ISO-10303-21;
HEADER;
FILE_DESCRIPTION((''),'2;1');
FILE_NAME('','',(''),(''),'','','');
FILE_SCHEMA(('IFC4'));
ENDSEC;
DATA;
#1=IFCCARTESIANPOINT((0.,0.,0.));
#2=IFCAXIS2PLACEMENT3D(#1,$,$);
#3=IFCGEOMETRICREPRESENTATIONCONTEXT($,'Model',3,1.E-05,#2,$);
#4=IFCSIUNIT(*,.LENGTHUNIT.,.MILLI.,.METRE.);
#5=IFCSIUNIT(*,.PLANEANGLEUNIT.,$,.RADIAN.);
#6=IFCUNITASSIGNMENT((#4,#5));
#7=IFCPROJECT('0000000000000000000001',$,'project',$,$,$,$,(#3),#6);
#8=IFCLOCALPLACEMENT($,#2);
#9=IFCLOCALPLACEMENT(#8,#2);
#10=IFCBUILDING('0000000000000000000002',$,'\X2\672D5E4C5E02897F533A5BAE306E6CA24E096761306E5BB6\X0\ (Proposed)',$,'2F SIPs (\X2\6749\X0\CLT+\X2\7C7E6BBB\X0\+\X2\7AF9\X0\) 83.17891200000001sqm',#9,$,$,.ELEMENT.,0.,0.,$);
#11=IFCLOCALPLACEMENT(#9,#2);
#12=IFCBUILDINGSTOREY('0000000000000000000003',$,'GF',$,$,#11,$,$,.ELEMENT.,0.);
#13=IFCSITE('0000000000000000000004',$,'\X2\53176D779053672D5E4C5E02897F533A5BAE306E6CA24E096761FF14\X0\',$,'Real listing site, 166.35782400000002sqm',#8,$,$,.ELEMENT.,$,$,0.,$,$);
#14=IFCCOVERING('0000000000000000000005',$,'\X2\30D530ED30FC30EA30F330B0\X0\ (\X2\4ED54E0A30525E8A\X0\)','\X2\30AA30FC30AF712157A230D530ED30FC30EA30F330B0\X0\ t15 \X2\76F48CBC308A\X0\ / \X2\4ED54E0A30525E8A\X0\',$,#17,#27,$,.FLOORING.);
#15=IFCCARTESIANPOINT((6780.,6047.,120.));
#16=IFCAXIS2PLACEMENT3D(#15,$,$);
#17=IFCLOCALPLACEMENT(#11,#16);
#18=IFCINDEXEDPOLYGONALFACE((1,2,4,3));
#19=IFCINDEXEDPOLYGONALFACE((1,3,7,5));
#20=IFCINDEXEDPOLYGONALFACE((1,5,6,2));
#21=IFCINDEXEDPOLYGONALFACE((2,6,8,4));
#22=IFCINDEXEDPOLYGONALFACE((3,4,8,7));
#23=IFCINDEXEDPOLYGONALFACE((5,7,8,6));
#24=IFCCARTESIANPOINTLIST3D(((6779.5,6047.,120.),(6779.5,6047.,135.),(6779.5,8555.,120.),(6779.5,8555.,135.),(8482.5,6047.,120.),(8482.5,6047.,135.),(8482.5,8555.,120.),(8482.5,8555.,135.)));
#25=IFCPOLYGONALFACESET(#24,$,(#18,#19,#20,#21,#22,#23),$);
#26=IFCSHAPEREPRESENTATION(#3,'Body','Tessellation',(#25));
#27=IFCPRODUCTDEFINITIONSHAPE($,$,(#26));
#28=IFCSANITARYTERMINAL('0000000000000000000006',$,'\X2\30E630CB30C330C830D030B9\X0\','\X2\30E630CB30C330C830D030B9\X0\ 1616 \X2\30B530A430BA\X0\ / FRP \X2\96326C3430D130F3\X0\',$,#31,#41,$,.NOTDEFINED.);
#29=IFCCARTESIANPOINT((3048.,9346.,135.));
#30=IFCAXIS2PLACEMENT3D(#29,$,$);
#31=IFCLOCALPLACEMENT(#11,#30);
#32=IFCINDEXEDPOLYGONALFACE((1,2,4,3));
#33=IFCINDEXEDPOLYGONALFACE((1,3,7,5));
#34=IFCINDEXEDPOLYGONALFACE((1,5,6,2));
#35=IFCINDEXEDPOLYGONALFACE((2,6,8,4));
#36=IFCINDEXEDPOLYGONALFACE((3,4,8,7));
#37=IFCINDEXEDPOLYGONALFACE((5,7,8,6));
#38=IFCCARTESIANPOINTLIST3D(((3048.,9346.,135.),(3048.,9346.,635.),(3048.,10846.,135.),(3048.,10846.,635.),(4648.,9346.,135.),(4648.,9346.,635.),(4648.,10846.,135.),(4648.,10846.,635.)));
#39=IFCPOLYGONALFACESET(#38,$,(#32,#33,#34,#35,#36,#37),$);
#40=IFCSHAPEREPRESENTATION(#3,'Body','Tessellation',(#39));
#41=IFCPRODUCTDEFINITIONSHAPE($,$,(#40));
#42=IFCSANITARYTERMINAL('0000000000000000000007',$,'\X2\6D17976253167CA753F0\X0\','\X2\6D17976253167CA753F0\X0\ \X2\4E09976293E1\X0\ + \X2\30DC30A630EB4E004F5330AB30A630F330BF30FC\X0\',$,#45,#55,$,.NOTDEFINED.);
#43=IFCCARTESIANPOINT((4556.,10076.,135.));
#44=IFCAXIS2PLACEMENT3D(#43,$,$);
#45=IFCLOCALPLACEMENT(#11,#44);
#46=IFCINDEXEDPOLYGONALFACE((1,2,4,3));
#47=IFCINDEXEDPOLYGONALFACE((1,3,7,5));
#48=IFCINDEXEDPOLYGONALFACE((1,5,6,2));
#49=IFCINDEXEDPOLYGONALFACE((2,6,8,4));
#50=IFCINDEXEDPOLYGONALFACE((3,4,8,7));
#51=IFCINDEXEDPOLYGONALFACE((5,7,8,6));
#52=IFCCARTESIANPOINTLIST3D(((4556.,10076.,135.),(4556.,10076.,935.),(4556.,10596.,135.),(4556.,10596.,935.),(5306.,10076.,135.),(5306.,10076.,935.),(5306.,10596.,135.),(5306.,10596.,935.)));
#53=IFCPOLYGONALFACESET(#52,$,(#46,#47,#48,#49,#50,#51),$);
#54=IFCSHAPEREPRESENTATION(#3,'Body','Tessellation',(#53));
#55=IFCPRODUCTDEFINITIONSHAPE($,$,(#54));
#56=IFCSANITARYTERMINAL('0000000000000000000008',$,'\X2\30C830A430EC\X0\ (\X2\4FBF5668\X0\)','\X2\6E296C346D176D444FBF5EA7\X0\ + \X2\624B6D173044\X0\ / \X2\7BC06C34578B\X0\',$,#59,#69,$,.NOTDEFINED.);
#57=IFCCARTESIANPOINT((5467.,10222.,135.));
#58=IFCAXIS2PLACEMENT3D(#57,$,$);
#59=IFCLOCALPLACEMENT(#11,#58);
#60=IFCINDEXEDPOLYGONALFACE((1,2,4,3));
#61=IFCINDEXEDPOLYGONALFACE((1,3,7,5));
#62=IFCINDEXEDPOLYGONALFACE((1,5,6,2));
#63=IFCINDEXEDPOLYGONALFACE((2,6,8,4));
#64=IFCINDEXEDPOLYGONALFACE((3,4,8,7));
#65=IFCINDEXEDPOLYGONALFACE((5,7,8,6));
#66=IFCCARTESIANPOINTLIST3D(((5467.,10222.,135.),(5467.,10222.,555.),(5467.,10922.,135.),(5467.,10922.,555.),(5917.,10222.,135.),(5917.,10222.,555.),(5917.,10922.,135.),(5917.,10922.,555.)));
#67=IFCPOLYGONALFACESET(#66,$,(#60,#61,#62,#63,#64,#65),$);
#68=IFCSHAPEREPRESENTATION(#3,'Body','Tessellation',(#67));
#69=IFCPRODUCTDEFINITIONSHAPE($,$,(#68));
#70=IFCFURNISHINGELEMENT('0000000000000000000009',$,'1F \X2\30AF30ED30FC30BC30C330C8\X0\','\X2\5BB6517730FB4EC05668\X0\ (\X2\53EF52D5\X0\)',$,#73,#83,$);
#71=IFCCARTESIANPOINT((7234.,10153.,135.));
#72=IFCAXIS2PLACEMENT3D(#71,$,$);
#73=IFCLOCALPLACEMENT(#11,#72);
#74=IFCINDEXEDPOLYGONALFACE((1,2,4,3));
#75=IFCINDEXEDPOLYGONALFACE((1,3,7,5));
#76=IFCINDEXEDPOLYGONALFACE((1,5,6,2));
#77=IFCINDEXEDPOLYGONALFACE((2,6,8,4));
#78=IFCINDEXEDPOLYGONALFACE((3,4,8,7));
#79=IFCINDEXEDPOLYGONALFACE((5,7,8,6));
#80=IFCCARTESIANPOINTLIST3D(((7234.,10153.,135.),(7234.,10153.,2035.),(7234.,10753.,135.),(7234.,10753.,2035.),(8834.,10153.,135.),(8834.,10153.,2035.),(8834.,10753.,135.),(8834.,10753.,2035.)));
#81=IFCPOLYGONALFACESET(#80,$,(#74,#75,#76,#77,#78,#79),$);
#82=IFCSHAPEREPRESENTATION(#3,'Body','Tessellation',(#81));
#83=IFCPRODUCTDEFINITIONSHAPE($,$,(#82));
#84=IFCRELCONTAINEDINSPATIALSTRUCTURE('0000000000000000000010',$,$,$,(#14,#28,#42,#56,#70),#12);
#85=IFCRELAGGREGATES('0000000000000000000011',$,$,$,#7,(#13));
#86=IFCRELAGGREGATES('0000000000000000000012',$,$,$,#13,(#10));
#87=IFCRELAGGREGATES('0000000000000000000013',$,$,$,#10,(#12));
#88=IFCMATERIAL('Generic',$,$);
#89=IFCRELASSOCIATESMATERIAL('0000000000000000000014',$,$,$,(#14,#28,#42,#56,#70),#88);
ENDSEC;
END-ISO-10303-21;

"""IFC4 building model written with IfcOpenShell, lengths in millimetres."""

from ifc_helpers import new_model, si_unit, frame, frame_2d, origin, place, context, project, spatial, rectangle, extrude, material, element, save


model = new_model("IFC4")

# Units and contexts
model_context = context("Model", 3, precision=1e-05, world=origin())
ifc_project = project(units=[si_unit("LENGTHUNIT", "METRE", prefix="MILLI"), si_unit("PLANEANGLEUNIT", "RADIAN")], contexts=[model_context])

# Site, building, storey
site_placement = place(None, origin())
site = spatial("IfcSite", under=ifc_project, at=site_placement, Name="北海道札幌市西区宮の沢三条４", ObjectType="Real listing site, 166.35782400000002sqm", CompositionType="ELEMENT", RefElevation=0.0)
building_placement = place(site_placement, origin())
building = spatial("IfcBuilding", under=site, at=building_placement, Name="札幌市西区宮の沢三条の家 (Proposed)", ObjectType="2F SIPs (杉CLT+籾殻+竹) 83.17891200000001sqm", CompositionType="ELEMENT", ElevationOfRefHeight=0.0, ElevationOfTerrain=0.0)
storey_placement = place(building_placement, origin())
storey = spatial("IfcBuildingStorey", under=building, at=storey_placement, Name="GF", CompositionType="ELEMENT", Elevation=0.0)

# Covering
ifc_material_1 = material(Name="Generic")
covering_1_placement = place(storey_placement, frame((6780.0, 6047.0, 120.0)))
element("IfcCovering", 1, at=covering_1_placement, inside=storey, material=ifc_material_1, Name="フローリング (仕上げ床)", Description="オーク無垢フローリング t15 直貼り / 仕上げ床", PredefinedType="FLOORING", context=model_context, shape_type="SweptSolid", body=[
    extrude(rectangle(XDim=1703.0, YDim=2508.0, at=frame_2d((851.0, 1254.0))), frame((6780.0, 6047.0, 120.0)), (0.0, 0.0, 1.0), 15.0),
])

# Sanitary terminals
sanitary_terminal_1_placement = place(storey_placement, frame((3048.0, 9346.0, 135.0)))
element("IfcSanitaryTerminal", 2, at=sanitary_terminal_1_placement, inside=storey, material=ifc_material_1, Name="ユニットバス", Description="ユニットバス 1616 サイズ / FRP 防水パン", PredefinedType="NOTDEFINED", context=model_context, shape_type="SweptSolid", body=[
    extrude(rectangle(XDim=1600.0, YDim=1500.0, at=frame_2d((800.0, 750.0))), frame((3048.0, 9346.0, 135.0)), (0.0, 0.0, 1.0), 500.0),
])
sanitary_terminal_2_placement = place(storey_placement, frame((4556.0, 10076.0, 135.0)))
element("IfcSanitaryTerminal", 3, at=sanitary_terminal_2_placement, inside=storey, material=ifc_material_1, Name="洗面化粧台", Description="洗面化粧台 三面鏡 + ボウル一体カウンター", PredefinedType="NOTDEFINED", context=model_context, shape_type="SweptSolid", body=[
    extrude(rectangle(XDim=750.0, YDim=520.0, at=frame_2d((375.0, 260.0))), frame((4556.0, 10076.0, 135.0)), (0.0, 0.0, 1.0), 800.0),
])
sanitary_terminal_3_placement = place(storey_placement, frame((5467.0, 10222.0, 135.0)))
element("IfcSanitaryTerminal", 4, at=sanitary_terminal_3_placement, inside=storey, material=ifc_material_1, Name="トイレ (便器)", Description="温水洗浄便座 + 手洗い / 節水型", PredefinedType="NOTDEFINED", context=model_context, shape_type="SweptSolid", body=[
    extrude(rectangle(XDim=450.0, YDim=700.0, at=frame_2d((225.0, 350.0))), frame((5467.0, 10222.0, 135.0)), (0.0, 0.0, 1.0), 420.0),
])

# Furnishing element
furnishing_placement = place(storey_placement, frame((7234.0, 10153.0, 135.0)))
element("IfcFurnishingElement", 5, at=furnishing_placement, inside=storey, material=ifc_material_1, Name="1F クローゼット", Description="家具・什器 (可動)", context=model_context, shape_type="SweptSolid", body=[
    extrude(rectangle(XDim=1600.0, YDim=600.0, at=frame_2d((800.0, 300.0))), frame((7234.0, 10153.0, 135.0)), (0.0, 0.0, 1.0), 1900.0),
])

save(model, "model.ifc")
